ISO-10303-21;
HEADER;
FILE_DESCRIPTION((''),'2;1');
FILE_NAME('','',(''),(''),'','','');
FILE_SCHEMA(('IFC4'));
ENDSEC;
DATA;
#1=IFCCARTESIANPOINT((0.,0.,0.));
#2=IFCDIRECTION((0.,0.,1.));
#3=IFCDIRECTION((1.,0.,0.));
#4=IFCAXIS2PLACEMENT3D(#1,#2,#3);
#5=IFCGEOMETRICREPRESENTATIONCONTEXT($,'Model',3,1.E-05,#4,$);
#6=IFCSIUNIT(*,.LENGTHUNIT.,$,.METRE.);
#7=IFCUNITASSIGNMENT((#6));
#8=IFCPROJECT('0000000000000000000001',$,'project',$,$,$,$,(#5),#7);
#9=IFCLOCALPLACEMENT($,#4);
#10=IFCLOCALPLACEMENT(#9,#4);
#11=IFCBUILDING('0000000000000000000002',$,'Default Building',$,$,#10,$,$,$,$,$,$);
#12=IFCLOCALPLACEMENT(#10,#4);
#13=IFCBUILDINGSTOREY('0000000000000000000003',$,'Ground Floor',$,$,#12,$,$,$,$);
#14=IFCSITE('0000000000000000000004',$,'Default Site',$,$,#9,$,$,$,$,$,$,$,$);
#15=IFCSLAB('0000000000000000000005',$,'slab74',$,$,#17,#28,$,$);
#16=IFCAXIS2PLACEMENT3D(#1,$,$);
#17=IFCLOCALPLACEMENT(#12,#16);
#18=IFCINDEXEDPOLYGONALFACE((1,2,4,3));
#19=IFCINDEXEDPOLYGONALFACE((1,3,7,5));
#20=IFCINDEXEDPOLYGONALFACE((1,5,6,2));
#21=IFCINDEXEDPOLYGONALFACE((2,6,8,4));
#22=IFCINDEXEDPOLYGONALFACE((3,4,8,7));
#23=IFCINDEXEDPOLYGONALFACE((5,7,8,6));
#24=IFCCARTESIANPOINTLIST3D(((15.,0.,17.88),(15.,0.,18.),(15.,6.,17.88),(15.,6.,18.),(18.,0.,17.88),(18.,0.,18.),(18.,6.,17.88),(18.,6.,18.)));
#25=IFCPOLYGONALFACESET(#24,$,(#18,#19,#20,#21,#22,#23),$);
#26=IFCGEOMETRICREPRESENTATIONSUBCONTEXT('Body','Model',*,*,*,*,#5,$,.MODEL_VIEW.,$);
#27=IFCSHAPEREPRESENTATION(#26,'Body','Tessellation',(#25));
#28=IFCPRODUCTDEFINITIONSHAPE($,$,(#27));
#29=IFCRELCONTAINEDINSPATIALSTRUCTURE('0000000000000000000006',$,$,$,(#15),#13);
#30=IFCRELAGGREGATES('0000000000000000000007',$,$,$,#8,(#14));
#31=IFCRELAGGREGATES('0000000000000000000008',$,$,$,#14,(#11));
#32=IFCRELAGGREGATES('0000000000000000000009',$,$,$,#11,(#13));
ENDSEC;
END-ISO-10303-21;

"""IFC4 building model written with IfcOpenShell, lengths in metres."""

from ifc_helpers import new_model, si_unit, frame, origin_with_axes, place, context, subcontext, project, spatial, indexed_curve, outline, extrude, element, save


model = new_model("IFC4")

# Units and contexts
model_context = context("Model", 3, precision=1e-05, world=origin_with_axes())
body_context = subcontext(model_context, "Body", "Model", "MODEL_VIEW")
ifc_project = project(units=[si_unit("LENGTHUNIT", "METRE")], contexts=[model_context])

# Site, building, storey
site_placement = place(None, origin_with_axes())
site = spatial("IfcSite", under=ifc_project, at=site_placement, Name="Default Site")
building_placement = place(site_placement, origin_with_axes())
building = spatial("IfcBuilding", under=site, at=building_placement, Name="Default Building")
storey_placement = place(building_placement, origin_with_axes())
storey = spatial("IfcBuildingStorey", under=building, at=storey_placement, Name="Ground Floor")

# Slab
for number, where, z_axis, x_axis, name in (
    (1, (15.0, 0.0, 17.88), (0.0, 0.0, 1.0), (1.0, 0.0, 0.0), "slab74"),
):
    element("IfcSlab", number, at=place(storey_placement, frame(where, z_axis=z_axis, x_axis=x_axis)), inside=storey, Name=name, context=body_context, shape_type="SweptSolid", body=[
        extrude(outline(indexed_curve([(0.0, 0.0), (0.0, 6.0), (3.0, 6.0), (3.0, 0.0), (0.0, 0.0)], self_intersect=False)), origin_with_axes(), (0.0, 0.0, 1.0), 0.12),
    ])

save(model, "model.ifc")
